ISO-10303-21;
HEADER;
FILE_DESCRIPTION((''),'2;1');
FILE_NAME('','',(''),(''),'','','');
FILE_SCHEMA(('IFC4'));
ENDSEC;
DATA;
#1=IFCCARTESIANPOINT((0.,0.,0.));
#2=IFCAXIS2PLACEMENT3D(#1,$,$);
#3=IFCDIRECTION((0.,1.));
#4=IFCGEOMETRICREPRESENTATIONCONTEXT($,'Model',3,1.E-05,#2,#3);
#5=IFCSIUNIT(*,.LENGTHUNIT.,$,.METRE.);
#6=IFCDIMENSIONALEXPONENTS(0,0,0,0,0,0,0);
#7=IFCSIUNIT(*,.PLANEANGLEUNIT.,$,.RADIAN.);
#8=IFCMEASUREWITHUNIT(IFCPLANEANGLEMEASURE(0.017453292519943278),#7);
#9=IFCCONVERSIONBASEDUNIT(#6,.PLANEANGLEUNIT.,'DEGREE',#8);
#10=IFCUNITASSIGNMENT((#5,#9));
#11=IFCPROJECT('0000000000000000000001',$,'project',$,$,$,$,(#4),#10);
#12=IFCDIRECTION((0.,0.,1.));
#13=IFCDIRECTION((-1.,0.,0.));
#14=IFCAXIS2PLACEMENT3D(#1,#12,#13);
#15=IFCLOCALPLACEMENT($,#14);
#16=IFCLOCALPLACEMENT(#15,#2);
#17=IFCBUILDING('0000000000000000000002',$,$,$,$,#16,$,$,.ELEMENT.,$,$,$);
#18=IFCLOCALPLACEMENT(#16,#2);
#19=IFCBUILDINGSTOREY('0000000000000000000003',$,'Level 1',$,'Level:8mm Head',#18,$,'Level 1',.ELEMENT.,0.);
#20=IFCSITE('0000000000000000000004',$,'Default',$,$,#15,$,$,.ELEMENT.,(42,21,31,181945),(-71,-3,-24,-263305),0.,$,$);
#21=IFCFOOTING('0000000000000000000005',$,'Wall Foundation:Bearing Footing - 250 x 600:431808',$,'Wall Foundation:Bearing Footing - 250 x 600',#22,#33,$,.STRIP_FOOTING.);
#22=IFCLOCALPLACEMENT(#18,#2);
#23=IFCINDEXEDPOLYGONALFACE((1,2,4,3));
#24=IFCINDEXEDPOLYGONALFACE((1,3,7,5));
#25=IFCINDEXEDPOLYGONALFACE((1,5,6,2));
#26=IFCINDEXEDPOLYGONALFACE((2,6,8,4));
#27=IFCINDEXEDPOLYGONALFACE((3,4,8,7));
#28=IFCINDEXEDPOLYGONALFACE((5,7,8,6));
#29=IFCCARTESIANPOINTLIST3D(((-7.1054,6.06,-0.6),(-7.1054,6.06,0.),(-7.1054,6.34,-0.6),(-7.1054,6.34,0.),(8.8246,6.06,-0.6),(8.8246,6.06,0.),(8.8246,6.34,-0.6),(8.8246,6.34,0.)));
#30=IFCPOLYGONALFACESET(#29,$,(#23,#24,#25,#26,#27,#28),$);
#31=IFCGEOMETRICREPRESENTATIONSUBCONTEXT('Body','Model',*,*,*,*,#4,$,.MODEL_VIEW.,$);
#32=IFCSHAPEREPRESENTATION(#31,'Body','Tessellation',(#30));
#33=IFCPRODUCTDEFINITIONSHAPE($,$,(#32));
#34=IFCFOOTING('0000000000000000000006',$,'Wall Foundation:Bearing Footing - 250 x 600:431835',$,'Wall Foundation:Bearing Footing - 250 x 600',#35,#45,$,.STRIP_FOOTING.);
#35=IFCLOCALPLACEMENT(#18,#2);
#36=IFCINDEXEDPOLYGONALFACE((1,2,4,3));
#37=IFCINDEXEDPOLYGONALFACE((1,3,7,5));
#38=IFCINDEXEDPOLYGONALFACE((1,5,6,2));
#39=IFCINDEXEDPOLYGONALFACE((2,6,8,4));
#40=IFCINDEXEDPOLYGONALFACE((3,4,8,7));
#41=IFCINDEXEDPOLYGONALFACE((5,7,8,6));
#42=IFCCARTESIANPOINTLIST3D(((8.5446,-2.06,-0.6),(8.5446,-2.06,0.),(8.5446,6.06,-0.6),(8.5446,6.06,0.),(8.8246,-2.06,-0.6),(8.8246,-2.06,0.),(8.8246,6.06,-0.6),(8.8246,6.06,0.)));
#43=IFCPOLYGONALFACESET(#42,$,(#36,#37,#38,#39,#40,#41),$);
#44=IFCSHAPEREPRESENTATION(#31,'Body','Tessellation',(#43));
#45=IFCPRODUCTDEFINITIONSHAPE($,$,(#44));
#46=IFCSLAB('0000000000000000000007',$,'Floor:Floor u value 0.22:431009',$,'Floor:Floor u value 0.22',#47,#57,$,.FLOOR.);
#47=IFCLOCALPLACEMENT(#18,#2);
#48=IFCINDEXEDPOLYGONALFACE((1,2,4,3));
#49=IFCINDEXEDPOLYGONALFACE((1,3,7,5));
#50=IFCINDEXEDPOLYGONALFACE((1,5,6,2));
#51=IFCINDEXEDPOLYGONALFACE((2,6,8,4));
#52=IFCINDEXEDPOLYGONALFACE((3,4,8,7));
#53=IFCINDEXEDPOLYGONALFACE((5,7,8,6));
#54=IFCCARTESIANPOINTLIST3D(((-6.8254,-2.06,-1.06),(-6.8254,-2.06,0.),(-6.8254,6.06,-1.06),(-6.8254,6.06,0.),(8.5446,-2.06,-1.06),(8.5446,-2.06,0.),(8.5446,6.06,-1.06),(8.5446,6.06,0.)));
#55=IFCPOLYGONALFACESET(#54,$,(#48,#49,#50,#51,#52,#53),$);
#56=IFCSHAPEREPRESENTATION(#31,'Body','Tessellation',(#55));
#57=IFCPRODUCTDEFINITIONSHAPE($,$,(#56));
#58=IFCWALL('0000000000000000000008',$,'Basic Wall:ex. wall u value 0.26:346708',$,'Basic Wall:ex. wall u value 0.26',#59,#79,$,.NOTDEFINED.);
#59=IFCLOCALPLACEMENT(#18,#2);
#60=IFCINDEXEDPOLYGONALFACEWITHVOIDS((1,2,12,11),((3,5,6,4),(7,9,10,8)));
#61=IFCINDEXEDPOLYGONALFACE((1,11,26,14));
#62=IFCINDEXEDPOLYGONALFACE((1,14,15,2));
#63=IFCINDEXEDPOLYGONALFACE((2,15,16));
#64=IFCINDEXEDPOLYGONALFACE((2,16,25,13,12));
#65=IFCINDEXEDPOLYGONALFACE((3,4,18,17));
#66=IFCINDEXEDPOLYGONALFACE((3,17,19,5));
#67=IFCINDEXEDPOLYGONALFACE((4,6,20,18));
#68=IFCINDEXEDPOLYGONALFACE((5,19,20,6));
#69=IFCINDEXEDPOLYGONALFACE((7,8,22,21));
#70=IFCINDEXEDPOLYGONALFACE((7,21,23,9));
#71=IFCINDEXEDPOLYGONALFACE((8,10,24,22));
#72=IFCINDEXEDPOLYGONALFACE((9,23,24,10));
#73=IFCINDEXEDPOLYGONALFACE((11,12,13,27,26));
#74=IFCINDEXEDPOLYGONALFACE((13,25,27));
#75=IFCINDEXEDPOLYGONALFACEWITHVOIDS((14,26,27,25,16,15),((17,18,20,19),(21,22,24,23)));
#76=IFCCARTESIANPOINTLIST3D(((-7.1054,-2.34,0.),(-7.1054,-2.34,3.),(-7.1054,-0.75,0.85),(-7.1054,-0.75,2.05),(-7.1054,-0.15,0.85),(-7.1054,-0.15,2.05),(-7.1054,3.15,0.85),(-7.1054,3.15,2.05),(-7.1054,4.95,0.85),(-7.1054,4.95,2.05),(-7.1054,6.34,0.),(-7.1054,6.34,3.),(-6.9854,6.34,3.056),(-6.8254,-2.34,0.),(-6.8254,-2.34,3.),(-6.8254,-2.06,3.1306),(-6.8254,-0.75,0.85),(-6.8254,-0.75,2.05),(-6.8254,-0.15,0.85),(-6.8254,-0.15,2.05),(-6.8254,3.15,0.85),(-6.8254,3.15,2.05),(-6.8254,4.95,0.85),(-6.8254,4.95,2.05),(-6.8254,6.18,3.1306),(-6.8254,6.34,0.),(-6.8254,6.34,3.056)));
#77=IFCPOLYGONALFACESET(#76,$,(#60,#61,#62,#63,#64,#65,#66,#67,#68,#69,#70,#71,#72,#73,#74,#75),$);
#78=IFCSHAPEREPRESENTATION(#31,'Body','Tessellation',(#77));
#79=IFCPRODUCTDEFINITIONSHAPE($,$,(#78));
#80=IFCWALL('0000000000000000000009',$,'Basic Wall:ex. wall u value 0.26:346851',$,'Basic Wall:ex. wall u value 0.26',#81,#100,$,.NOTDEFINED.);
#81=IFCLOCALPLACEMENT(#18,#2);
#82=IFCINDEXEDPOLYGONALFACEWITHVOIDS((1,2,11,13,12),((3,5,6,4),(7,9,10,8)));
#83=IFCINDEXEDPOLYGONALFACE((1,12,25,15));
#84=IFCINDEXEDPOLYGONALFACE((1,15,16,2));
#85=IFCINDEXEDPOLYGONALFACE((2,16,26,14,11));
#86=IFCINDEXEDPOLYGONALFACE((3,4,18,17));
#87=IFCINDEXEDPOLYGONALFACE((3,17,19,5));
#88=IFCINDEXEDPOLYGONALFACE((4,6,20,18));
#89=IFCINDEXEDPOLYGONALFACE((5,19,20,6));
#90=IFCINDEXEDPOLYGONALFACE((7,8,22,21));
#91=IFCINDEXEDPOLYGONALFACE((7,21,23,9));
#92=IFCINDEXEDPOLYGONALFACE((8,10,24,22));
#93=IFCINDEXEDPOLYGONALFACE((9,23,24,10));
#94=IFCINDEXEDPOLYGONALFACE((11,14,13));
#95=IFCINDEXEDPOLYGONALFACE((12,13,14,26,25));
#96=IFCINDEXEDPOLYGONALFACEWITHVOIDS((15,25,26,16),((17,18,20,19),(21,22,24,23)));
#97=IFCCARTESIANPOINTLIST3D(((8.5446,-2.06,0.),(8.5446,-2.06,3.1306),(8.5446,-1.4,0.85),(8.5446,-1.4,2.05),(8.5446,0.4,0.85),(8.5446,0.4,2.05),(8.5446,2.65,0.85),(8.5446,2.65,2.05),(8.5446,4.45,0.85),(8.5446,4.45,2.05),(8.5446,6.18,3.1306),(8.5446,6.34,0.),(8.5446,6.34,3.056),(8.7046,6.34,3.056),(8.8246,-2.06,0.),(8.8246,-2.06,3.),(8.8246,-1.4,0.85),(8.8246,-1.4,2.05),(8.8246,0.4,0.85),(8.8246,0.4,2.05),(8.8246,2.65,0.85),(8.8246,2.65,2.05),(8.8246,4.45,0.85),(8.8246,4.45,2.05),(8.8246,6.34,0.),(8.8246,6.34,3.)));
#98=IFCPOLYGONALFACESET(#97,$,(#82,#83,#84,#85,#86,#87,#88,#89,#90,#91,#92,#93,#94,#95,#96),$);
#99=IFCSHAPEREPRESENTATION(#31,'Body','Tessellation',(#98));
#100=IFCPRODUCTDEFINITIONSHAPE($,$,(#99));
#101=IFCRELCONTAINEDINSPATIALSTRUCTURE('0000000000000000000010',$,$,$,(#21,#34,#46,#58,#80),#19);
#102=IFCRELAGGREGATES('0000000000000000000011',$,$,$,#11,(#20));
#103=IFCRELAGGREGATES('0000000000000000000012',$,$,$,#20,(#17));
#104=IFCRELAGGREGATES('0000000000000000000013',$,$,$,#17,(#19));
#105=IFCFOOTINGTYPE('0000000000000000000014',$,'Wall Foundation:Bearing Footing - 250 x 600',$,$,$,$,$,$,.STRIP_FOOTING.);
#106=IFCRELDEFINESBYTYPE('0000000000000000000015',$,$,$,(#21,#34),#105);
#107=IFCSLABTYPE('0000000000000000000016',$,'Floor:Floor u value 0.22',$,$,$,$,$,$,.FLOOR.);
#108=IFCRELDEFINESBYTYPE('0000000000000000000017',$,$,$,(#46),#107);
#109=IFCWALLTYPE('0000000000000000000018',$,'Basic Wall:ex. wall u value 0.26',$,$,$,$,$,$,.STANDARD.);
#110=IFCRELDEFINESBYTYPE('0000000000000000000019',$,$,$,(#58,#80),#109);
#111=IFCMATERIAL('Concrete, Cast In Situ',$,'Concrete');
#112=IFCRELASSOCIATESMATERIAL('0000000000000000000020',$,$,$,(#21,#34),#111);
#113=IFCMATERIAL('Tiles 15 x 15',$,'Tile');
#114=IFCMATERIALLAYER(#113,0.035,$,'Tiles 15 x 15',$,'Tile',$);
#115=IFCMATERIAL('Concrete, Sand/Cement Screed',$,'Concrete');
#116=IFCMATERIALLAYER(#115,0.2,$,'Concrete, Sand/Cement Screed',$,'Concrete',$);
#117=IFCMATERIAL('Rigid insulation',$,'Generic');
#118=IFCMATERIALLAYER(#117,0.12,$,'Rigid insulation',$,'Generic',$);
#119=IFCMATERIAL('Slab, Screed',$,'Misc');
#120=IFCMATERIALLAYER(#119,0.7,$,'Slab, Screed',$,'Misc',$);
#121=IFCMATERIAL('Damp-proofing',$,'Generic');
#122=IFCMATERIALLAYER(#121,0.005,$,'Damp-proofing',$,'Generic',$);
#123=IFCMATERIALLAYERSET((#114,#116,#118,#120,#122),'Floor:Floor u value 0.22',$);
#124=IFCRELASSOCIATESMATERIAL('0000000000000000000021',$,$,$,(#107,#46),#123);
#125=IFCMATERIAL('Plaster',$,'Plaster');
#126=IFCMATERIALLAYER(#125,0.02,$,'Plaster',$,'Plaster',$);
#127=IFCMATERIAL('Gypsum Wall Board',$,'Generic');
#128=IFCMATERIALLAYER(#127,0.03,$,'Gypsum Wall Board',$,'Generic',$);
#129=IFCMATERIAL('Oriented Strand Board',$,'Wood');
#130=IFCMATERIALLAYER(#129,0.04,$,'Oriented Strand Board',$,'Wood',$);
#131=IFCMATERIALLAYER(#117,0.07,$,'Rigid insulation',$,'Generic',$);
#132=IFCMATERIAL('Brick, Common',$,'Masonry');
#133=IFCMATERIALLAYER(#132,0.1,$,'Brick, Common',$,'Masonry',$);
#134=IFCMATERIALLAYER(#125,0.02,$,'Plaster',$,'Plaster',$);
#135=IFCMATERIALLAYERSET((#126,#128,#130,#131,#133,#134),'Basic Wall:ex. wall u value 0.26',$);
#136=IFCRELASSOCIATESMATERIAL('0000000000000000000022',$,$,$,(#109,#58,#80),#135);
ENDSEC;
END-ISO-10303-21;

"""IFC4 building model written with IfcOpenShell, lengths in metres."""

from ifc_helpers import new_model, entity, si_unit, converted_unit, direction, frame, frame_2d, origin, origin_2d_with_axis, place, context, subcontext, project, spatial, polyline, rectangle, extrude, clip, bounded_halfspace, material, layer, layer_set, layer_usage, type_object, element, save


model = new_model("IFC4")

# Units and contexts
model_context = context("Model", 3, precision=1e-05, world=origin(), true_north=direction((0.0, 1.0)))
body_context = subcontext(model_context, "Body", "Model", "MODEL_VIEW")
ifc_project = project(units=[si_unit("LENGTHUNIT", "METRE"), converted_unit("PLANEANGLEUNIT", "DEGREE", entity("IfcPlaneAngleMeasure", 0.017453292519943278), si_unit("PLANEANGLEUNIT", "RADIAN"), dimensions=[0, 0, 0, 0, 0, 0, 0])], contexts=[model_context])

# Site, building, storey
site_placement = place(None, frame((0.0, 0.0, 0.0), z_axis=(0.0, 0.0, 1.0), x_axis=(-1.0, 0.0, 0.0)))
site = spatial("IfcSite", under=ifc_project, at=site_placement, Name="Default", CompositionType="ELEMENT", RefLatitude=(42, 21, 31, 181945), RefLongitude=(-71, -3, -24, -263305), RefElevation=0.0)
building_placement = place(site_placement, origin())
building = spatial("IfcBuilding", under=site, at=building_placement, CompositionType="ELEMENT")
storey_placement = place(building_placement, origin())
storey = spatial("IfcBuildingStorey", under=building, at=storey_placement, Name="Level 1", ObjectType="Level:8mm Head", LongName="Level 1", CompositionType="ELEMENT", Elevation=0.0)

# Footings
ifc_material_1 = material(Name="Concrete, Cast In Situ", Category="Concrete")
footing_type = type_object("IfcFootingType", Name="Wall Foundation:Bearing Footing - 250 x 600", PredefinedType="STRIP_FOOTING")
footing_1_placement = place(storey_placement, frame((-7.1054, 6.06, -0.6)))
element("IfcFooting", 1, at=footing_1_placement, inside=storey, type_object=footing_type, material=ifc_material_1, Name="Wall Foundation:Bearing Footing - 250 x 600:431808", ObjectType="Wall Foundation:Bearing Footing - 250 x 600", PredefinedType="STRIP_FOOTING", context=body_context, shape_type="SweptSolid", body=[
    extrude(rectangle(XDim=15.93, YDim=0.28, at=frame_2d((0.0, -0.0467), x_axis=(1.0, 0.0))), frame((7.965, 0.0933, 0.0), z_axis=(0.0, 0.0, 1.0), x_axis=(-1.0, 0.0, 0.0)), (0.0, 0.0, 1.0), 0.6),
])
footing_2_placement = place(storey_placement, frame((8.5446, -2.06, -0.6)))
element("IfcFooting", 2, at=footing_2_placement, inside=storey, type_object=footing_type, material=ifc_material_1, Name="Wall Foundation:Bearing Footing - 250 x 600:431835", ObjectType="Wall Foundation:Bearing Footing - 250 x 600", PredefinedType="STRIP_FOOTING", context=body_context, shape_type="SweptSolid", body=[
    extrude(rectangle(XDim=8.12, YDim=0.28, at=frame_2d((0.0, 0.0), x_axis=(1.0, 0.0))), frame((0.14, 4.06, 0.0), z_axis=(0.0, 0.0, 1.0), x_axis=(0.0, -1.0, 0.0)), (0.0, 0.0, 1.0), 0.6),
])

# Slab
ifc_material_2 = material(Name="Tiles 15 x 15", Category="Tile")
ifc_layer_1 = layer(ifc_material_2, 0.035, Name="Tiles 15 x 15", Category="Tile")
ifc_material_3 = material(Name="Concrete, Sand/Cement Screed", Category="Concrete")
ifc_layer_2 = layer(ifc_material_3, 0.2, Name="Concrete, Sand/Cement Screed", Category="Concrete")
ifc_material_4 = material(Name="Rigid insulation", Category="Generic")
ifc_layer_3 = layer(ifc_material_4, 0.12, Name="Rigid insulation", Category="Generic")
ifc_material_5 = material(Name="Slab, Screed", Category="Misc")
ifc_layer_4 = layer(ifc_material_5, 0.7, Name="Slab, Screed", Category="Misc")
ifc_material_6 = material(Name="Damp-proofing", Category="Generic")
ifc_layer_5 = layer(ifc_material_6, 0.005, Name="Damp-proofing", Category="Generic")
ifc_layer_set_1 = layer_set([ifc_layer_1, ifc_layer_2, ifc_layer_3, ifc_layer_4, ifc_layer_5], Name="Floor:Floor u value 0.22")
ifc_layer_usage_1 = layer_usage(ifc_layer_set_1, "AXIS3", "POSITIVE", 0.0)
slab_type = type_object("IfcSlabType", Name="Floor:Floor u value 0.22", PredefinedType="FLOOR", material=ifc_layer_set_1)
slab_placement = place(storey_placement, origin())
element("IfcSlab", 3, at=slab_placement, inside=storey, type_object=slab_type, material=ifc_layer_usage_1, Name="Floor:Floor u value 0.22:431009", ObjectType="Floor:Floor u value 0.22", PredefinedType="FLOOR", context=body_context, shape_type="SweptSolid", body=[
    extrude(rectangle(XDim=8.12, YDim=15.37, at=origin_2d_with_axis()), frame((0.8596, 2.0, 0.0), z_axis=(0.0, 0.0, -1.0), x_axis=(0.0, 1.0, 0.0)), (0.0, 0.0, 1.0), 1.06),
])

# Walls, openings
ifc_material_7 = material(Name="Plaster", Category="Plaster")
ifc_layer_6 = layer(ifc_material_7, 0.02, Name="Plaster", Category="Plaster")
ifc_material_8 = material(Name="Gypsum Wall Board", Category="Generic")
ifc_layer_7 = layer(ifc_material_8, 0.03, Name="Gypsum Wall Board", Category="Generic")
ifc_material_9 = material(Name="Oriented Strand Board", Category="Wood")
ifc_layer_8 = layer(ifc_material_9, 0.04, Name="Oriented Strand Board", Category="Wood")
ifc_layer_9 = layer(ifc_material_4, 0.07, Name="Rigid insulation", Category="Generic")
ifc_material_10 = material(Name="Brick, Common", Category="Masonry")
ifc_layer_10 = layer(ifc_material_10, 0.1, Name="Brick, Common", Category="Masonry")
ifc_layer_11 = layer(ifc_material_7, 0.02, Name="Plaster", Category="Plaster")
ifc_layer_set_2 = layer_set([ifc_layer_6, ifc_layer_7, ifc_layer_8, ifc_layer_9, ifc_layer_10, ifc_layer_11], Name="Basic Wall:ex. wall u value 0.26")
ifc_layer_usage_2 = layer_usage(ifc_layer_set_2, "AXIS2", "POSITIVE", -0.14)
wall_type_1 = type_object("IfcWallType", Name="Basic Wall:ex. wall u value 0.26", PredefinedType="STANDARD", material=ifc_layer_set_2)
wall_1_placement = place(storey_placement, frame((-6.9654, 6.34, 0.0), z_axis=(0.0, 0.0, 1.0), x_axis=(0.0, -1.0, 0.0)))
wall_1 = element("IfcWall", 4, at=wall_1_placement, inside=storey, type_object=wall_type_1, material=ifc_layer_usage_2, Name="Basic Wall:ex. wall u value 0.26:346708", ObjectType="Basic Wall:ex. wall u value 0.26", PredefinedType="NOTDEFINED", context=body_context, shape_type="Clipping", body=[
    clip(clip(clip(extrude(rectangle(XDim=8.68, YDim=0.28, at=frame_2d((4.34, 0.0), x_axis=(-1.0, 0.0))), origin(), (0.0, 0.0, 1.0), 3.1306), bounded_halfspace(frame((0.16, 0.14, 3.1306), z_axis=(-0.422618, 0.0, 0.906308), x_axis=(0.0, -1.0, 0.0)), False, frame((0.16, 0.14, 3.1306)), polyline([(0.0, 0.0), (-0.16, 0.0), (-0.16, -0.16), (0.0, 0.0)]))), bounded_halfspace(frame((0.0, -0.14, 3.0), z_axis=(0.0, -0.422618, 0.906308), x_axis=(1.0, 0.0, 0.0)), False, frame((0.0, -0.14, 3.0)), polyline([(0.0, 0.0), (8.68, 0.0), (8.4, 0.28), (0.28, 0.28), (0.16, 0.28), (0.0, 0.12), (0.0, 0.0)]))), bounded_halfspace(frame((8.68, -0.14, 3.0), z_axis=(0.422618, 0.0, 0.906308), x_axis=(0.0, 1.0, 0.0)), False, frame((8.68, -0.14, 3.0)), polyline([(0.0, 0.0), (0.0, 0.28), (-0.28, 0.28), (0.0, 0.0)]))),
])
opening_1_placement = place(wall_1_placement, frame((3.19, 0.14, 0.85)))
element("IfcOpeningElement", 5, at=opening_1_placement, cuts=wall_1, PredefinedType="OPENING", context=body_context, shape_type="SweptSolid", body=[
    extrude(rectangle(XDim=1.2, YDim=1.8, at=frame_2d((0.6, 0.9), x_axis=(1.0, 0.0))), frame((0.0, 0.0, 0.0), z_axis=(0.0, -1.0, 0.0), x_axis=(0.0, 0.0, 1.0)), (0.0, 0.0, 1.0), 0.28),
])
opening_2_placement = place(wall_1_placement, frame((7.09, 0.14, 0.85)))
element("IfcOpeningElement", 6, at=opening_2_placement, cuts=wall_1, PredefinedType="OPENING", context=body_context, shape_type="SweptSolid", body=[
    extrude(rectangle(XDim=1.2, YDim=0.6, at=frame_2d((0.6, 0.3), x_axis=(1.0, 0.0))), frame((0.0, 0.0, 0.0), z_axis=(0.0, -1.0, 0.0), x_axis=(0.0, 0.0, 1.0)), (0.0, 0.0, 1.0), 0.28),
])
wall_2_placement = place(storey_placement, frame((8.6846, -2.06, 0.0), z_axis=(0.0, 0.0, 1.0), x_axis=(0.0, 1.0, 0.0)))
wall_2 = element("IfcWall", 7, at=wall_2_placement, inside=storey, type_object=wall_type_1, material=ifc_layer_usage_2, Name="Basic Wall:ex. wall u value 0.26:346851", ObjectType="Basic Wall:ex. wall u value 0.26", PredefinedType="NOTDEFINED", context=body_context, shape_type="Clipping", body=[
    clip(clip(extrude(rectangle(XDim=8.4, YDim=0.28, at=frame_2d((4.2, 0.0), x_axis=(-1.0, 0.0))), origin(), (0.0, 0.0, 1.0), 3.1306), bounded_halfspace(frame((8.4, -0.02, 3.056), z_axis=(0.422618, 0.0, 0.906308), x_axis=(0.0, 1.0, 0.0)), False, frame((8.4, -0.02, 3.056)), polyline([(0.0, 0.0), (0.0, 0.16), (-0.16, 0.16), (0.0, 0.0)]))), bounded_halfspace(frame((0.0, -0.14, 3.0), z_axis=(0.0, -0.422618, 0.906308), x_axis=(1.0, 0.0, 0.0)), False, frame((0.0, -0.14, 3.0)), polyline([(0.0, 0.0), (8.4, 0.0), (8.4, 0.12), (8.24, 0.28), (8.12, 0.28), (0.0, 0.28), (0.0, 0.0)]))),
])
opening_3_placement = place(wall_2_placement, frame((6.51, 0.14, 0.85)))
element("IfcOpeningElement", 8, at=opening_3_placement, cuts=wall_2, PredefinedType="OPENING", context=body_context, shape_type="SweptSolid", body=[
    extrude(rectangle(XDim=1.2, YDim=1.8, at=frame_2d((0.6, 0.9), x_axis=(1.0, 0.0))), frame((0.0, 0.0, 0.0), z_axis=(0.0, -1.0, 0.0), x_axis=(0.0, 0.0, 1.0)), (0.0, 0.0, 1.0), 0.28),
])
opening_4_placement = place(wall_2_placement, frame((2.46, 0.14, 0.85)))
element("IfcOpeningElement", 9, at=opening_4_placement, cuts=wall_2, PredefinedType="OPENING", context=body_context, shape_type="SweptSolid", body=[
    extrude(rectangle(XDim=1.2, YDim=1.8, at=frame_2d((0.6, 0.9), x_axis=(1.0, 0.0))), frame((0.0, 0.0, 0.0), z_axis=(0.0, -1.0, 0.0), x_axis=(0.0, 0.0, 1.0)), (0.0, 0.0, 1.0), 0.28),
])

save(model, "model.ifc")
